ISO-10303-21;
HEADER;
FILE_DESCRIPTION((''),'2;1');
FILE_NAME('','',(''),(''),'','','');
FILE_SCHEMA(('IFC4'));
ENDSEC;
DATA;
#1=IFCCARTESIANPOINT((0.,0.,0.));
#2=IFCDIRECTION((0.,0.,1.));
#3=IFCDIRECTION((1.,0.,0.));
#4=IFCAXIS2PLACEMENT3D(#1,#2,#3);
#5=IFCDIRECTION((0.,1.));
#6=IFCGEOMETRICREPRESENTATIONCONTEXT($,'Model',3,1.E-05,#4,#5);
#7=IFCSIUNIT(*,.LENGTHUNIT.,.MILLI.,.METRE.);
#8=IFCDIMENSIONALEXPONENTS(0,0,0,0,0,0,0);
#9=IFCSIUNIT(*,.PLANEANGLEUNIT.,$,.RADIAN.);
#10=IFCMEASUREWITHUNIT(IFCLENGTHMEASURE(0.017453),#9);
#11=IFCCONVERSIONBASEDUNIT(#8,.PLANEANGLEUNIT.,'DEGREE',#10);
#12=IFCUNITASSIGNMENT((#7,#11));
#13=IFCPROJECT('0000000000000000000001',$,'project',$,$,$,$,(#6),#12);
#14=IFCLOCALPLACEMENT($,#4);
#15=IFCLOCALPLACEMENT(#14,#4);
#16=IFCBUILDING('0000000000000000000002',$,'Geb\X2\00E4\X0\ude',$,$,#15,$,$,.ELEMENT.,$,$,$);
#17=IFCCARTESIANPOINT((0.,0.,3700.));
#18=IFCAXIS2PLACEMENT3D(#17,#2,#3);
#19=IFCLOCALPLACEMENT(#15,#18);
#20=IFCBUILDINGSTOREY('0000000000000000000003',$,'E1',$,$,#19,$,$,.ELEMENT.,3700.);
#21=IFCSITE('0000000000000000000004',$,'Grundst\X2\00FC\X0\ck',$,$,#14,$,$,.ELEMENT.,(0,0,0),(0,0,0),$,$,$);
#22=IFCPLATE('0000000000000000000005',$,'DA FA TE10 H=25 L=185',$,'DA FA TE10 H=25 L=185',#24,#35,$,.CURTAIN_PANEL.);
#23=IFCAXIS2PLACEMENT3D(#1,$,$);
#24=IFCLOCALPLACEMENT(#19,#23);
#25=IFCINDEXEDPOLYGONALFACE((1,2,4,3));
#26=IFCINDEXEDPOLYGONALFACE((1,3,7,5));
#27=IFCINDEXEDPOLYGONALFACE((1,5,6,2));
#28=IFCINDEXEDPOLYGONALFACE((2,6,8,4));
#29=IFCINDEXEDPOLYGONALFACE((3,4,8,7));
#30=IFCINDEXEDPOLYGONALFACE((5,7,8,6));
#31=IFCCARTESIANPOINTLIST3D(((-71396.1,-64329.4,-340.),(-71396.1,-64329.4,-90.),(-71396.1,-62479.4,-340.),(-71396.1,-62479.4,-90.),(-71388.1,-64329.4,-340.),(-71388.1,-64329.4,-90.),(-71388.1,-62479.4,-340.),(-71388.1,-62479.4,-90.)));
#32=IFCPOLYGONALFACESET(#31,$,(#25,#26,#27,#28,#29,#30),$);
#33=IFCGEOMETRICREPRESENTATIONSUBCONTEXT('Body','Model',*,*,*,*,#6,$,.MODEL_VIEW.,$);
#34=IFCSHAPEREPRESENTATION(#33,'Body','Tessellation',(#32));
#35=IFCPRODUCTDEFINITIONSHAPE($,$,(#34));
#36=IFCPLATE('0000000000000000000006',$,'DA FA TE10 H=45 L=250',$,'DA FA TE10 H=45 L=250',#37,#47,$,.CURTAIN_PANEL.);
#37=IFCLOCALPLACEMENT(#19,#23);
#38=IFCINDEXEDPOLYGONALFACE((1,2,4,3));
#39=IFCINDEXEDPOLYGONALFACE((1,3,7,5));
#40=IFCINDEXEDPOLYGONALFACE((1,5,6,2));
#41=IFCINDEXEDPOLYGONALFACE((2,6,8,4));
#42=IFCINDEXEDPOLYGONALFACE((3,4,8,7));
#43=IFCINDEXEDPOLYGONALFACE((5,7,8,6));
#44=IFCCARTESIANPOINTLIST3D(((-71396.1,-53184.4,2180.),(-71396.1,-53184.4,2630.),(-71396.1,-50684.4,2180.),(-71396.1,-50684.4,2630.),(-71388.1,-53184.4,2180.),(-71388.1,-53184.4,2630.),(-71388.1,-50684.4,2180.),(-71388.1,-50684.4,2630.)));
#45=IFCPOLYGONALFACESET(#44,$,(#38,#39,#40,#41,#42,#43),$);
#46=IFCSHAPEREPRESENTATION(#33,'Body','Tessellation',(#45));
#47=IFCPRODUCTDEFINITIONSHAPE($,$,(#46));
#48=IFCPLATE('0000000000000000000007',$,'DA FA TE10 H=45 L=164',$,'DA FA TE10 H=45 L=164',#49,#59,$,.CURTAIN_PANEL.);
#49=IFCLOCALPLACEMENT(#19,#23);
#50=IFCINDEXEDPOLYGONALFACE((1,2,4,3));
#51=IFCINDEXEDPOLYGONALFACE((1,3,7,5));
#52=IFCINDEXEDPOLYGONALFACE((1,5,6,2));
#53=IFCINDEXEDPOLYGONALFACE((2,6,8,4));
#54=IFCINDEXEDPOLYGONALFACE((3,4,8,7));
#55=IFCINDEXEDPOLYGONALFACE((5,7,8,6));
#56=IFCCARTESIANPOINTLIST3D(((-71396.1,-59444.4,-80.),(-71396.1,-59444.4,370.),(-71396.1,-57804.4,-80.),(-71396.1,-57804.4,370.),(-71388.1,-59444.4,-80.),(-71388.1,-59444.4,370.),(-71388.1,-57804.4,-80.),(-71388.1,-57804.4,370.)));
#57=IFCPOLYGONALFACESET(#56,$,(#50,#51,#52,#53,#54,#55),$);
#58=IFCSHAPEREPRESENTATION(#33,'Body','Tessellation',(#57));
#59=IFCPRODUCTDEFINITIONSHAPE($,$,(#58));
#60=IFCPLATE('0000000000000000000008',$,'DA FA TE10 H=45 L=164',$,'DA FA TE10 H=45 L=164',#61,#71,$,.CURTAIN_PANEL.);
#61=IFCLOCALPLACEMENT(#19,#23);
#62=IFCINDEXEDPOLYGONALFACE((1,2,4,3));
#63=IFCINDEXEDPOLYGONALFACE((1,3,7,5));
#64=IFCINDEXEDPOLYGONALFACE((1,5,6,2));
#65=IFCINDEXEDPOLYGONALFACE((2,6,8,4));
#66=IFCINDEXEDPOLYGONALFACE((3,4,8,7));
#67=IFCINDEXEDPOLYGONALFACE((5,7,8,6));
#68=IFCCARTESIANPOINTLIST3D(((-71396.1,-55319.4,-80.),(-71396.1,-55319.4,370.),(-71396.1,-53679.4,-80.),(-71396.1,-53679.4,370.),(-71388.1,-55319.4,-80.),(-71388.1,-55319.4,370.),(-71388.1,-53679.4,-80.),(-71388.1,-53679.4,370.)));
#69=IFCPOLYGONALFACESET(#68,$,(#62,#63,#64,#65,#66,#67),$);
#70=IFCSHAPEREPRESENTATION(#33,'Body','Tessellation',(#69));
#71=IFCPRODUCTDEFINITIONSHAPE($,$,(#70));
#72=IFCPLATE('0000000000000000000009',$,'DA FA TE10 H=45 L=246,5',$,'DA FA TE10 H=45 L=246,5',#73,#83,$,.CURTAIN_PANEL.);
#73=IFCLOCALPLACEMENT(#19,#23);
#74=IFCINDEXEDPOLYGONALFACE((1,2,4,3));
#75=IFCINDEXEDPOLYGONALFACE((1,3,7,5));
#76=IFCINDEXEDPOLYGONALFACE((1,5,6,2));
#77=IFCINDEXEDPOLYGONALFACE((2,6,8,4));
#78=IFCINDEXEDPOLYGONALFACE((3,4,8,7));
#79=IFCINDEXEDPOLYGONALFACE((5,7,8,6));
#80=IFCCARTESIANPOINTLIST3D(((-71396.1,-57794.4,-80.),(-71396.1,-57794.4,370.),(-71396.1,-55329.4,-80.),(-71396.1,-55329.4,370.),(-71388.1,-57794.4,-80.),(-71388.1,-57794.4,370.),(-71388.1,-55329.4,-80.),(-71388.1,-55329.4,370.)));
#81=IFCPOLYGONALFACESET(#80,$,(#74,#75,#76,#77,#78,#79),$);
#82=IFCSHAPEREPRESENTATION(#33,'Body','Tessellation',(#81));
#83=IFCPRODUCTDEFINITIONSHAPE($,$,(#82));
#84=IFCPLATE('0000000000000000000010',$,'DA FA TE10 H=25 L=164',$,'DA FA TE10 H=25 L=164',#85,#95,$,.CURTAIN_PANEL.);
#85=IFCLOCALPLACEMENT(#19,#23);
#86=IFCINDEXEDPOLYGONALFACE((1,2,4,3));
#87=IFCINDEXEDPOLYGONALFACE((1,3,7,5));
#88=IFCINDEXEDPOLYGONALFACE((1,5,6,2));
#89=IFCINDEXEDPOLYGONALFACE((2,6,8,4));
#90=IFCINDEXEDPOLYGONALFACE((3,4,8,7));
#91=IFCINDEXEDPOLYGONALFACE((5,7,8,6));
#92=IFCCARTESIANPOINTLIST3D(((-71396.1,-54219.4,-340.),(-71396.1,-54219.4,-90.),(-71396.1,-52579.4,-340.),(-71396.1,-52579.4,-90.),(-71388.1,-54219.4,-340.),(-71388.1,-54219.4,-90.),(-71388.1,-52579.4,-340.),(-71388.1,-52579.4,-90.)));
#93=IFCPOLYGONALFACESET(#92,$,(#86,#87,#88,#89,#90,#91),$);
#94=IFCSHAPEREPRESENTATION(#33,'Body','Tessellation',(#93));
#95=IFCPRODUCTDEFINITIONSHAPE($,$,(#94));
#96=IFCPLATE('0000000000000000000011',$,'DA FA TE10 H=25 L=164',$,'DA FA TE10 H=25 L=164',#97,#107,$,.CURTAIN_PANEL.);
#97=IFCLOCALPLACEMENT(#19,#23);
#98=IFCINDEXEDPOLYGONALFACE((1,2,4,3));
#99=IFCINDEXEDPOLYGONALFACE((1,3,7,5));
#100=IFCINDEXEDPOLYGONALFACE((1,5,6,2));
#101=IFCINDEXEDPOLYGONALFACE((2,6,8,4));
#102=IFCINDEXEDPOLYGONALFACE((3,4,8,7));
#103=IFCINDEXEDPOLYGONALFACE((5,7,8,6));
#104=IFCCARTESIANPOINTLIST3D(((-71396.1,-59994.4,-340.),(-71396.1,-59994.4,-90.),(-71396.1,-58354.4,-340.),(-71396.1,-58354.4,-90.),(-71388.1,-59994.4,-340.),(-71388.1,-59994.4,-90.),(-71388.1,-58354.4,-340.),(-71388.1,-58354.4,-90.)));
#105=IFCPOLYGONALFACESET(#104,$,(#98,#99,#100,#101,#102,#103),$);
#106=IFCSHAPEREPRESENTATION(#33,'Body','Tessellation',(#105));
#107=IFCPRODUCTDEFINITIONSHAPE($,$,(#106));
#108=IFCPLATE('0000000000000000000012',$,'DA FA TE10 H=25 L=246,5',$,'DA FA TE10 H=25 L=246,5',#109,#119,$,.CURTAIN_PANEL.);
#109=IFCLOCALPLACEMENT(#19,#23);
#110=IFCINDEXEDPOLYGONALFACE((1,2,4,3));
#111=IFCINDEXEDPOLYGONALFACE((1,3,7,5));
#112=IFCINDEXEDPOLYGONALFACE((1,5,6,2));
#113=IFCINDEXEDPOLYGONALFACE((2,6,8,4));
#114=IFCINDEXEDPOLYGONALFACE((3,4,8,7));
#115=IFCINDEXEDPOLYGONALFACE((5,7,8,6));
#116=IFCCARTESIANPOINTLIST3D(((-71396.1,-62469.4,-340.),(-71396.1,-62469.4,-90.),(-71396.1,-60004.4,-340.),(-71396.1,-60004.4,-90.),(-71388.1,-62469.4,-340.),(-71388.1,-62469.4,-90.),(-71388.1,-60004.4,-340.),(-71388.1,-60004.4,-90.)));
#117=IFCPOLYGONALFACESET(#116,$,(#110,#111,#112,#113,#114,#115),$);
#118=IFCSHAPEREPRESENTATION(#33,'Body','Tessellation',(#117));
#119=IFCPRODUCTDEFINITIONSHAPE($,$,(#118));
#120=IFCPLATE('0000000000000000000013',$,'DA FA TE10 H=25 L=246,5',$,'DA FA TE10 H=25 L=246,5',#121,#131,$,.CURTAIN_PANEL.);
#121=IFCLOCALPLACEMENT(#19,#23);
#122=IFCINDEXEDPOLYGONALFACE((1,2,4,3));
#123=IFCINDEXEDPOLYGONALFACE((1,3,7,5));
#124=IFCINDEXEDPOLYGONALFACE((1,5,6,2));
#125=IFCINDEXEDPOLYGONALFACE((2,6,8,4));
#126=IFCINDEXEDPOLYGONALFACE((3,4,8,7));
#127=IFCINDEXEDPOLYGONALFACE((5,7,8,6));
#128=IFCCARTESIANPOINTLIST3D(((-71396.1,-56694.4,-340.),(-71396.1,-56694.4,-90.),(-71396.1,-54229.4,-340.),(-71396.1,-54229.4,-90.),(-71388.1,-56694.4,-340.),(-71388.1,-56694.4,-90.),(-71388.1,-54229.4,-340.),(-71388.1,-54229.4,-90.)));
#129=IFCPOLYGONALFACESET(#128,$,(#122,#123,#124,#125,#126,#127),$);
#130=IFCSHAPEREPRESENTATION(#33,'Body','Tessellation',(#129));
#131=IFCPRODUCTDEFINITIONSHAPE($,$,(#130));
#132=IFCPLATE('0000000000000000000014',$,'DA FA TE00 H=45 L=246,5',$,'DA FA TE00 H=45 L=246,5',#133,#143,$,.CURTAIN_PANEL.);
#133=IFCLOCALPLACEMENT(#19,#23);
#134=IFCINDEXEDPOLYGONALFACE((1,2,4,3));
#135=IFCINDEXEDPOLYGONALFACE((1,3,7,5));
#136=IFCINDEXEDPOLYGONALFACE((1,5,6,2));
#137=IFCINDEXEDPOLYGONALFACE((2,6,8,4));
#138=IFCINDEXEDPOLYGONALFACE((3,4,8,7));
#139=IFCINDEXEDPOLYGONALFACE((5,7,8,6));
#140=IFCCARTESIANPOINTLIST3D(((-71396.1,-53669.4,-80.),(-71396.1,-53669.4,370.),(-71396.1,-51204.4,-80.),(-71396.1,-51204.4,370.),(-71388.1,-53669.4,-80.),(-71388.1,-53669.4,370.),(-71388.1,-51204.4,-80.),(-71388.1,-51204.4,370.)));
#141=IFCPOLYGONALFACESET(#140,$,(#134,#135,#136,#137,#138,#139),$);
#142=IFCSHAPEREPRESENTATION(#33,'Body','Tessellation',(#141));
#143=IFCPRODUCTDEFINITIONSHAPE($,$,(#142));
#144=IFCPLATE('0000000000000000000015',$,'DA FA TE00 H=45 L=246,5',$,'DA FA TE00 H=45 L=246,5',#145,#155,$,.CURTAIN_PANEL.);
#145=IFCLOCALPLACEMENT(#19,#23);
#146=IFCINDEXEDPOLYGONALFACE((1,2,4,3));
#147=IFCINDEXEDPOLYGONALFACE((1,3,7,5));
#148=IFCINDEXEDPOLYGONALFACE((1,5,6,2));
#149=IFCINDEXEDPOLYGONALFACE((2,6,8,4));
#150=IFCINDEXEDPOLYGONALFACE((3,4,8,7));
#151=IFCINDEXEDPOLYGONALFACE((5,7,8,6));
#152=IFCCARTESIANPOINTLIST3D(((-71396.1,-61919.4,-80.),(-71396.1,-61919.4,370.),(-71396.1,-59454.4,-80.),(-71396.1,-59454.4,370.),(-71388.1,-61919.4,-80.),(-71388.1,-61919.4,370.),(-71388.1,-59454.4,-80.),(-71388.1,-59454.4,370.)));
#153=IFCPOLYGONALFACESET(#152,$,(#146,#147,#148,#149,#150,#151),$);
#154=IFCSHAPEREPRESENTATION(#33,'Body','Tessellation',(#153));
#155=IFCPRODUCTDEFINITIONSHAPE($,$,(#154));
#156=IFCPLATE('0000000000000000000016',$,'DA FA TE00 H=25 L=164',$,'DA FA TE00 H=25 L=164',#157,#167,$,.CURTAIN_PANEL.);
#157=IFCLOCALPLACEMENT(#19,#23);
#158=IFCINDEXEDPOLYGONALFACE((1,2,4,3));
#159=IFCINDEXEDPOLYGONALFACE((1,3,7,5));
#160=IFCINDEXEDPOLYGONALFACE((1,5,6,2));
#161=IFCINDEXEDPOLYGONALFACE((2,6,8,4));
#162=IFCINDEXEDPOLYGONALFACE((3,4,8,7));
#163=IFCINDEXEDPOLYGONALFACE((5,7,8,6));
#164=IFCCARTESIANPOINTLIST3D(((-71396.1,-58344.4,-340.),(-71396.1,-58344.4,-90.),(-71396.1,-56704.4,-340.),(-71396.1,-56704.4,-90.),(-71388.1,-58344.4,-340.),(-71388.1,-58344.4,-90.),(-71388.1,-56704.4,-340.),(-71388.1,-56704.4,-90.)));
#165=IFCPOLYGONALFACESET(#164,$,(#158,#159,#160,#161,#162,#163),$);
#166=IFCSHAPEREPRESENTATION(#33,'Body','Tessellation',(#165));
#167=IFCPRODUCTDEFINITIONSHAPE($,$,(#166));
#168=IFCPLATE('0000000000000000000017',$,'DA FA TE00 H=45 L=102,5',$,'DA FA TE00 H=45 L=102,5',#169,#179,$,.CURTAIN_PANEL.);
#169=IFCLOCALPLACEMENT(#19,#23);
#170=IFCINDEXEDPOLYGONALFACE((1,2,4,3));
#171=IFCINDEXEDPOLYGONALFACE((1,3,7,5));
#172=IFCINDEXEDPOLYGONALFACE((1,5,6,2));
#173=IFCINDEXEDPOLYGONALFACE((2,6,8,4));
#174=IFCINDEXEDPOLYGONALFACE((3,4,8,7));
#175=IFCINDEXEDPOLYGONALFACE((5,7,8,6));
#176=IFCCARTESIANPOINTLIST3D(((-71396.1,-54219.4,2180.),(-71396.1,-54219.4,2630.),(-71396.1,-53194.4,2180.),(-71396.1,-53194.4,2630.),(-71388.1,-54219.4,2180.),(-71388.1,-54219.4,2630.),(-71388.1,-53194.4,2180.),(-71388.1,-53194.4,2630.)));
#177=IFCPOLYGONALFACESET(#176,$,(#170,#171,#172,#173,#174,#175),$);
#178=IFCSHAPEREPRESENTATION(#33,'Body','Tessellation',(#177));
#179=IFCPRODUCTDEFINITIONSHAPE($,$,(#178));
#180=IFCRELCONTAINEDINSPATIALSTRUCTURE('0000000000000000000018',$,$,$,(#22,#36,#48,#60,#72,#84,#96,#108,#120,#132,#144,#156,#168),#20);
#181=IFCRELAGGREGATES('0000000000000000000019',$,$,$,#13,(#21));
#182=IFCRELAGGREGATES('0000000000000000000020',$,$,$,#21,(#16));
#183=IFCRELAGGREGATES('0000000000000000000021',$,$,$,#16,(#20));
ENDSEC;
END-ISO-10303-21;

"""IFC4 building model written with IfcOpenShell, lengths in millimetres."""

from ifc_helpers import new_model, entity, si_unit, converted_unit, direction, frame, origin_with_axes, place, context, subcontext, project, spatial, line, indexed_curve, outline, extrude, source, transform, mapped, element, save


model = new_model("IFC4")

# Units and contexts
model_context = context("Model", 3, precision=1e-05, world=origin_with_axes(), true_north=direction((0.0, 1.0)))
body_context = subcontext(model_context, "Body", "Model", "MODEL_VIEW")
ifc_project = project(units=[si_unit("LENGTHUNIT", "METRE", prefix="MILLI"), converted_unit("PLANEANGLEUNIT", "DEGREE", entity("IfcLengthMeasure", 0.017453), si_unit("PLANEANGLEUNIT", "RADIAN"), dimensions=[0, 0, 0, 0, 0, 0, 0])], contexts=[model_context])

# Site, building, storey
site_placement = place(None, origin_with_axes())
site = spatial("IfcSite", under=ifc_project, at=site_placement, Name="Grundstück", CompositionType="ELEMENT", RefLatitude=(0, 0, 0), RefLongitude=(0, 0, 0))
building_placement = place(site_placement, origin_with_axes())
building = spatial("IfcBuilding", under=site, at=building_placement, Name="Gebäude", CompositionType="ELEMENT")
storey_placement = place(building_placement, frame((0.0, 0.0, 3700.0), z_axis=(0.0, 0.0, 1.0), x_axis=(1.0, 0.0, 0.0)))
storey = spatial("IfcBuildingStorey", under=building, at=storey_placement, Name="E1", CompositionType="ELEMENT", Elevation=3700.0)

# Plates
shared_shape_1 = source(origin_with_axes(), body_context, "Body", "SweptSolid", [
    extrude(outline(indexed_curve([(-925.0, 0.0), (925.0, 0.0), (925.0, 8.0), (-925.0, 8.0)], segments=[line(1, 2), line(2, 3), line(3, 4), line(4, 1)])), frame((0.0, 0.0, 250.0), z_axis=(0.0, 0.0, 1.0), x_axis=(1.0, 0.0, 0.0)), (0.0, 0.0, -1.0), 250.0),
])
plate_1_placement = place(storey_placement, frame((-71396.1, -63404.4, -340.0), z_axis=(0.0, 0.0, 1.0), x_axis=(0.0, -1.0, 0.0)))
element("IfcPlate", 1, at=plate_1_placement, inside=storey, Name="DA FA TE10 H=25 L=185", ObjectType="DA FA TE10 H=25 L=185", PredefinedType="CURTAIN_PANEL", context=body_context, shape_type="MappedRepresentation", body=[
    mapped(shared_shape_1, transform((0.0, 0.0, 0.0), x_axis=(1.0, 0.0, 0.0), y_axis=(0.0, 1.0, 0.0), z_axis=(0.0, 0.0, 1.0), scale=1.0)),
])
shared_shape_2 = source(origin_with_axes(), body_context, "Body", "SweptSolid", [
    extrude(outline(indexed_curve([(-1250.0, 0.0), (1250.0, 0.0), (1250.0, 8.0), (-1250.0, 8.0)], segments=[line(1, 2), line(2, 3), line(3, 4), line(4, 1)])), frame((0.0, 0.0, 450.0), z_axis=(0.0, 0.0, 1.0), x_axis=(1.0, 0.0, 0.0)), (0.0, 0.0, -1.0), 450.0),
])
plate_2_placement = place(storey_placement, frame((-71396.1, -51934.4, 2180.0), z_axis=(0.0, 0.0, 1.0), x_axis=(0.0, -1.0, 0.0)))
element("IfcPlate", 2, at=plate_2_placement, inside=storey, Name="DA FA TE10 H=45 L=250", ObjectType="DA FA TE10 H=45 L=250", PredefinedType="CURTAIN_PANEL", context=body_context, shape_type="MappedRepresentation", body=[
    mapped(shared_shape_2, transform((0.0, 0.0, 0.0), x_axis=(1.0, 0.0, 0.0), y_axis=(0.0, 1.0, 0.0), z_axis=(0.0, 0.0, 1.0), scale=1.0)),
])
shared_shape_3 = source(origin_with_axes(), body_context, "Body", "SweptSolid", [
    extrude(outline(indexed_curve([(-820.0, 0.0), (820.0, 0.0), (820.0, 8.0), (-820.0, 8.0)], segments=[line(1, 2), line(2, 3), line(3, 4), line(4, 1)])), frame((0.0, 0.0, 450.0), z_axis=(0.0, 0.0, 1.0), x_axis=(1.0, 0.0, 0.0)), (0.0, 0.0, -1.0), 450.0),
])
for number, where, z_axis, x_axis, name in (
    (3, (-71396.1, -58624.4, -80.0), (0.0, 0.0, 1.0), (0.0, -1.0, 0.0), "DA FA TE10 H=45 L=164"),
    (4, (-71396.1, -54499.4, -80.0), (0.0, 0.0, 1.0), (0.0, -1.0, 0.0), "DA FA TE10 H=45 L=164"),
):
    element("IfcPlate", number, at=place(storey_placement, frame(where, z_axis=z_axis, x_axis=x_axis)), inside=storey, Name=name, ObjectType="DA FA TE10 H=45 L=164", PredefinedType="CURTAIN_PANEL", context=body_context, shape_type="MappedRepresentation", body=[
        mapped(shared_shape_3, transform((0.0, 0.0, 0.0), x_axis=(1.0, 0.0, 0.0), y_axis=(0.0, 1.0, 0.0), z_axis=(0.0, 0.0, 1.0), scale=1.0)),
    ])
shared_shape_4 = source(origin_with_axes(), body_context, "Body", "SweptSolid", [
    extrude(outline(indexed_curve([(-1232.5, 0.0), (1232.5, 0.0), (1232.5, 8.0), (-1232.5, 8.0)], segments=[line(1, 2), line(2, 3), line(3, 4), line(4, 1)])), frame((0.0, 0.0, 450.0), z_axis=(0.0, 0.0, 1.0), x_axis=(1.0, 0.0, 0.0)), (0.0, 0.0, -1.0), 450.0),
])
plate_3_placement = place(storey_placement, frame((-71396.1, -56561.9, -80.0), z_axis=(0.0, 0.0, 1.0), x_axis=(0.0, -1.0, 0.0)))
element("IfcPlate", 5, at=plate_3_placement, inside=storey, Name="DA FA TE10 H=45 L=246,5", ObjectType="DA FA TE10 H=45 L=246,5", PredefinedType="CURTAIN_PANEL", context=body_context, shape_type="MappedRepresentation", body=[
    mapped(shared_shape_4, transform((0.0, 0.0, 0.0), x_axis=(1.0, 0.0, 0.0), y_axis=(0.0, 1.0, 0.0), z_axis=(0.0, 0.0, 1.0), scale=1.0)),
])
shared_shape_5 = source(origin_with_axes(), body_context, "Body", "SweptSolid", [
    extrude(outline(indexed_curve([(-820.0, 0.0), (820.0, 0.0), (820.0, 8.0), (-820.0, 8.0)], segments=[line(1, 2), line(2, 3), line(3, 4), line(4, 1)])), frame((0.0, 0.0, 250.0), z_axis=(0.0, 0.0, 1.0), x_axis=(1.0, 0.0, 0.0)), (0.0, 0.0, -1.0), 250.0),
])
for number, where, z_axis, x_axis, name in (
    (6, (-71396.1, -53399.4, -340.0), (0.0, 0.0, 1.0), (0.0, -1.0, 0.0), "DA FA TE10 H=25 L=164"),
    (7, (-71396.1, -59174.4, -340.0), (0.0, 0.0, 1.0), (0.0, -1.0, 0.0), "DA FA TE10 H=25 L=164"),
):
    element("IfcPlate", number, at=place(storey_placement, frame(where, z_axis=z_axis, x_axis=x_axis)), inside=storey, Name=name, ObjectType="DA FA TE10 H=25 L=164", PredefinedType="CURTAIN_PANEL", context=body_context, shape_type="MappedRepresentation", body=[
        mapped(shared_shape_5, transform((0.0, 0.0, 0.0), x_axis=(1.0, 0.0, 0.0), y_axis=(0.0, 1.0, 0.0), z_axis=(0.0, 0.0, 1.0), scale=1.0)),
    ])
shared_shape_6 = source(origin_with_axes(), body_context, "Body", "SweptSolid", [
    extrude(outline(indexed_curve([(-1232.5, 0.0), (1232.5, 0.0), (1232.5, 8.0), (-1232.5, 8.0)], segments=[line(1, 2), line(2, 3), line(3, 4), line(4, 1)])), frame((0.0, 0.0, 250.0), z_axis=(0.0, 0.0, 1.0), x_axis=(1.0, 0.0, 0.0)), (0.0, 0.0, -1.0), 250.0),
])
for number, where, z_axis, x_axis, name in (
    (8, (-71396.1, -61236.9, -340.0), (0.0, 0.0, 1.0), (0.0, -1.0, 0.0), "DA FA TE10 H=25 L=246,5"),
    (9, (-71396.1, -55461.9, -340.0), (0.0, 0.0, 1.0), (0.0, -1.0, 0.0), "DA FA TE10 H=25 L=246,5"),
):
    element("IfcPlate", number, at=place(storey_placement, frame(where, z_axis=z_axis, x_axis=x_axis)), inside=storey, Name=name, ObjectType="DA FA TE10 H=25 L=246,5", PredefinedType="CURTAIN_PANEL", context=body_context, shape_type="MappedRepresentation", body=[
        mapped(shared_shape_6, transform((0.0, 0.0, 0.0), x_axis=(1.0, 0.0, 0.0), y_axis=(0.0, 1.0, 0.0), z_axis=(0.0, 0.0, 1.0), scale=1.0)),
    ])
shared_shape_7 = source(origin_with_axes(), body_context, "Body", "SweptSolid", [
    extrude(outline(indexed_curve([(-1232.5, 0.0), (1232.5, 0.0), (1232.5, 8.0), (-1232.5, 8.0)], segments=[line(1, 2), line(2, 3), line(3, 4), line(4, 1)])), frame((0.0, 0.0, 450.0), z_axis=(0.0, 0.0, 1.0), x_axis=(1.0, 0.0, 0.0)), (0.0, 0.0, -1.0), 450.0),
])
for number, where, z_axis, x_axis, name in (
    (10, (-71396.1, -52436.9, -80.0), (0.0, 0.0, 1.0), (0.0, -1.0, 0.0), "DA FA TE00 H=45 L=246,5"),
    (11, (-71396.1, -60686.9, -80.0), (0.0, 0.0, 1.0), (0.0, -1.0, 0.0), "DA FA TE00 H=45 L=246,5"),
):
    element("IfcPlate", number, at=place(storey_placement, frame(where, z_axis=z_axis, x_axis=x_axis)), inside=storey, Name=name, ObjectType="DA FA TE00 H=45 L=246,5", PredefinedType="CURTAIN_PANEL", context=body_context, shape_type="MappedRepresentation", body=[
        mapped(shared_shape_7, transform((0.0, 0.0, 0.0), x_axis=(1.0, 0.0, 0.0), y_axis=(0.0, 1.0, 0.0), z_axis=(0.0, 0.0, 1.0), scale=1.0)),
    ])
shared_shape_8 = source(origin_with_axes(), body_context, "Body", "SweptSolid", [
    extrude(outline(indexed_curve([(-820.0, 0.0), (820.0, 0.0), (820.0, 8.0), (-820.0, 8.0)], segments=[line(1, 2), line(2, 3), line(3, 4), line(4, 1)])), frame((0.0, 0.0, 250.0), z_axis=(0.0, 0.0, 1.0), x_axis=(1.0, 0.0, 0.0)), (0.0, 0.0, -1.0), 250.0),
])
plate_4_placement = place(storey_placement, frame((-71396.1, -57524.4, -340.0), z_axis=(0.0, 0.0, 1.0), x_axis=(0.0, -1.0, 0.0)))
element("IfcPlate", 12, at=plate_4_placement, inside=storey, Name="DA FA TE00 H=25 L=164", ObjectType="DA FA TE00 H=25 L=164", PredefinedType="CURTAIN_PANEL", context=body_context, shape_type="MappedRepresentation", body=[
    mapped(shared_shape_8, transform((0.0, 0.0, 0.0), x_axis=(1.0, 0.0, 0.0), y_axis=(0.0, 1.0, 0.0), z_axis=(0.0, 0.0, 1.0), scale=1.0)),
])
shared_shape_9 = source(origin_with_axes(), body_context, "Body", "SweptSolid", [
    extrude(outline(indexed_curve([(-512.5, 0.0), (512.5, 0.0), (512.5, 8.0), (-512.5, 8.0)], segments=[line(1, 2), line(2, 3), line(3, 4), line(4, 1)])), frame((0.0, 0.0, 450.0), z_axis=(0.0, 0.0, 1.0), x_axis=(1.0, 0.0, 0.0)), (0.0, 0.0, -1.0), 450.0),
])
plate_5_placement = place(storey_placement, frame((-71396.1, -53706.9, 2180.0), z_axis=(0.0, 0.0, 1.0), x_axis=(0.0, -1.0, 0.0)))
element("IfcPlate", 13, at=plate_5_placement, inside=storey, Name="DA FA TE00 H=45 L=102,5", ObjectType="DA FA TE00 H=45 L=102,5", PredefinedType="CURTAIN_PANEL", context=body_context, shape_type="MappedRepresentation", body=[
    mapped(shared_shape_9, transform((0.0, 0.0, 0.0), x_axis=(1.0, 0.0, 0.0), y_axis=(0.0, 1.0, 0.0), z_axis=(0.0, 0.0, 1.0), scale=1.0)),
])

save(model, "model.ifc")
